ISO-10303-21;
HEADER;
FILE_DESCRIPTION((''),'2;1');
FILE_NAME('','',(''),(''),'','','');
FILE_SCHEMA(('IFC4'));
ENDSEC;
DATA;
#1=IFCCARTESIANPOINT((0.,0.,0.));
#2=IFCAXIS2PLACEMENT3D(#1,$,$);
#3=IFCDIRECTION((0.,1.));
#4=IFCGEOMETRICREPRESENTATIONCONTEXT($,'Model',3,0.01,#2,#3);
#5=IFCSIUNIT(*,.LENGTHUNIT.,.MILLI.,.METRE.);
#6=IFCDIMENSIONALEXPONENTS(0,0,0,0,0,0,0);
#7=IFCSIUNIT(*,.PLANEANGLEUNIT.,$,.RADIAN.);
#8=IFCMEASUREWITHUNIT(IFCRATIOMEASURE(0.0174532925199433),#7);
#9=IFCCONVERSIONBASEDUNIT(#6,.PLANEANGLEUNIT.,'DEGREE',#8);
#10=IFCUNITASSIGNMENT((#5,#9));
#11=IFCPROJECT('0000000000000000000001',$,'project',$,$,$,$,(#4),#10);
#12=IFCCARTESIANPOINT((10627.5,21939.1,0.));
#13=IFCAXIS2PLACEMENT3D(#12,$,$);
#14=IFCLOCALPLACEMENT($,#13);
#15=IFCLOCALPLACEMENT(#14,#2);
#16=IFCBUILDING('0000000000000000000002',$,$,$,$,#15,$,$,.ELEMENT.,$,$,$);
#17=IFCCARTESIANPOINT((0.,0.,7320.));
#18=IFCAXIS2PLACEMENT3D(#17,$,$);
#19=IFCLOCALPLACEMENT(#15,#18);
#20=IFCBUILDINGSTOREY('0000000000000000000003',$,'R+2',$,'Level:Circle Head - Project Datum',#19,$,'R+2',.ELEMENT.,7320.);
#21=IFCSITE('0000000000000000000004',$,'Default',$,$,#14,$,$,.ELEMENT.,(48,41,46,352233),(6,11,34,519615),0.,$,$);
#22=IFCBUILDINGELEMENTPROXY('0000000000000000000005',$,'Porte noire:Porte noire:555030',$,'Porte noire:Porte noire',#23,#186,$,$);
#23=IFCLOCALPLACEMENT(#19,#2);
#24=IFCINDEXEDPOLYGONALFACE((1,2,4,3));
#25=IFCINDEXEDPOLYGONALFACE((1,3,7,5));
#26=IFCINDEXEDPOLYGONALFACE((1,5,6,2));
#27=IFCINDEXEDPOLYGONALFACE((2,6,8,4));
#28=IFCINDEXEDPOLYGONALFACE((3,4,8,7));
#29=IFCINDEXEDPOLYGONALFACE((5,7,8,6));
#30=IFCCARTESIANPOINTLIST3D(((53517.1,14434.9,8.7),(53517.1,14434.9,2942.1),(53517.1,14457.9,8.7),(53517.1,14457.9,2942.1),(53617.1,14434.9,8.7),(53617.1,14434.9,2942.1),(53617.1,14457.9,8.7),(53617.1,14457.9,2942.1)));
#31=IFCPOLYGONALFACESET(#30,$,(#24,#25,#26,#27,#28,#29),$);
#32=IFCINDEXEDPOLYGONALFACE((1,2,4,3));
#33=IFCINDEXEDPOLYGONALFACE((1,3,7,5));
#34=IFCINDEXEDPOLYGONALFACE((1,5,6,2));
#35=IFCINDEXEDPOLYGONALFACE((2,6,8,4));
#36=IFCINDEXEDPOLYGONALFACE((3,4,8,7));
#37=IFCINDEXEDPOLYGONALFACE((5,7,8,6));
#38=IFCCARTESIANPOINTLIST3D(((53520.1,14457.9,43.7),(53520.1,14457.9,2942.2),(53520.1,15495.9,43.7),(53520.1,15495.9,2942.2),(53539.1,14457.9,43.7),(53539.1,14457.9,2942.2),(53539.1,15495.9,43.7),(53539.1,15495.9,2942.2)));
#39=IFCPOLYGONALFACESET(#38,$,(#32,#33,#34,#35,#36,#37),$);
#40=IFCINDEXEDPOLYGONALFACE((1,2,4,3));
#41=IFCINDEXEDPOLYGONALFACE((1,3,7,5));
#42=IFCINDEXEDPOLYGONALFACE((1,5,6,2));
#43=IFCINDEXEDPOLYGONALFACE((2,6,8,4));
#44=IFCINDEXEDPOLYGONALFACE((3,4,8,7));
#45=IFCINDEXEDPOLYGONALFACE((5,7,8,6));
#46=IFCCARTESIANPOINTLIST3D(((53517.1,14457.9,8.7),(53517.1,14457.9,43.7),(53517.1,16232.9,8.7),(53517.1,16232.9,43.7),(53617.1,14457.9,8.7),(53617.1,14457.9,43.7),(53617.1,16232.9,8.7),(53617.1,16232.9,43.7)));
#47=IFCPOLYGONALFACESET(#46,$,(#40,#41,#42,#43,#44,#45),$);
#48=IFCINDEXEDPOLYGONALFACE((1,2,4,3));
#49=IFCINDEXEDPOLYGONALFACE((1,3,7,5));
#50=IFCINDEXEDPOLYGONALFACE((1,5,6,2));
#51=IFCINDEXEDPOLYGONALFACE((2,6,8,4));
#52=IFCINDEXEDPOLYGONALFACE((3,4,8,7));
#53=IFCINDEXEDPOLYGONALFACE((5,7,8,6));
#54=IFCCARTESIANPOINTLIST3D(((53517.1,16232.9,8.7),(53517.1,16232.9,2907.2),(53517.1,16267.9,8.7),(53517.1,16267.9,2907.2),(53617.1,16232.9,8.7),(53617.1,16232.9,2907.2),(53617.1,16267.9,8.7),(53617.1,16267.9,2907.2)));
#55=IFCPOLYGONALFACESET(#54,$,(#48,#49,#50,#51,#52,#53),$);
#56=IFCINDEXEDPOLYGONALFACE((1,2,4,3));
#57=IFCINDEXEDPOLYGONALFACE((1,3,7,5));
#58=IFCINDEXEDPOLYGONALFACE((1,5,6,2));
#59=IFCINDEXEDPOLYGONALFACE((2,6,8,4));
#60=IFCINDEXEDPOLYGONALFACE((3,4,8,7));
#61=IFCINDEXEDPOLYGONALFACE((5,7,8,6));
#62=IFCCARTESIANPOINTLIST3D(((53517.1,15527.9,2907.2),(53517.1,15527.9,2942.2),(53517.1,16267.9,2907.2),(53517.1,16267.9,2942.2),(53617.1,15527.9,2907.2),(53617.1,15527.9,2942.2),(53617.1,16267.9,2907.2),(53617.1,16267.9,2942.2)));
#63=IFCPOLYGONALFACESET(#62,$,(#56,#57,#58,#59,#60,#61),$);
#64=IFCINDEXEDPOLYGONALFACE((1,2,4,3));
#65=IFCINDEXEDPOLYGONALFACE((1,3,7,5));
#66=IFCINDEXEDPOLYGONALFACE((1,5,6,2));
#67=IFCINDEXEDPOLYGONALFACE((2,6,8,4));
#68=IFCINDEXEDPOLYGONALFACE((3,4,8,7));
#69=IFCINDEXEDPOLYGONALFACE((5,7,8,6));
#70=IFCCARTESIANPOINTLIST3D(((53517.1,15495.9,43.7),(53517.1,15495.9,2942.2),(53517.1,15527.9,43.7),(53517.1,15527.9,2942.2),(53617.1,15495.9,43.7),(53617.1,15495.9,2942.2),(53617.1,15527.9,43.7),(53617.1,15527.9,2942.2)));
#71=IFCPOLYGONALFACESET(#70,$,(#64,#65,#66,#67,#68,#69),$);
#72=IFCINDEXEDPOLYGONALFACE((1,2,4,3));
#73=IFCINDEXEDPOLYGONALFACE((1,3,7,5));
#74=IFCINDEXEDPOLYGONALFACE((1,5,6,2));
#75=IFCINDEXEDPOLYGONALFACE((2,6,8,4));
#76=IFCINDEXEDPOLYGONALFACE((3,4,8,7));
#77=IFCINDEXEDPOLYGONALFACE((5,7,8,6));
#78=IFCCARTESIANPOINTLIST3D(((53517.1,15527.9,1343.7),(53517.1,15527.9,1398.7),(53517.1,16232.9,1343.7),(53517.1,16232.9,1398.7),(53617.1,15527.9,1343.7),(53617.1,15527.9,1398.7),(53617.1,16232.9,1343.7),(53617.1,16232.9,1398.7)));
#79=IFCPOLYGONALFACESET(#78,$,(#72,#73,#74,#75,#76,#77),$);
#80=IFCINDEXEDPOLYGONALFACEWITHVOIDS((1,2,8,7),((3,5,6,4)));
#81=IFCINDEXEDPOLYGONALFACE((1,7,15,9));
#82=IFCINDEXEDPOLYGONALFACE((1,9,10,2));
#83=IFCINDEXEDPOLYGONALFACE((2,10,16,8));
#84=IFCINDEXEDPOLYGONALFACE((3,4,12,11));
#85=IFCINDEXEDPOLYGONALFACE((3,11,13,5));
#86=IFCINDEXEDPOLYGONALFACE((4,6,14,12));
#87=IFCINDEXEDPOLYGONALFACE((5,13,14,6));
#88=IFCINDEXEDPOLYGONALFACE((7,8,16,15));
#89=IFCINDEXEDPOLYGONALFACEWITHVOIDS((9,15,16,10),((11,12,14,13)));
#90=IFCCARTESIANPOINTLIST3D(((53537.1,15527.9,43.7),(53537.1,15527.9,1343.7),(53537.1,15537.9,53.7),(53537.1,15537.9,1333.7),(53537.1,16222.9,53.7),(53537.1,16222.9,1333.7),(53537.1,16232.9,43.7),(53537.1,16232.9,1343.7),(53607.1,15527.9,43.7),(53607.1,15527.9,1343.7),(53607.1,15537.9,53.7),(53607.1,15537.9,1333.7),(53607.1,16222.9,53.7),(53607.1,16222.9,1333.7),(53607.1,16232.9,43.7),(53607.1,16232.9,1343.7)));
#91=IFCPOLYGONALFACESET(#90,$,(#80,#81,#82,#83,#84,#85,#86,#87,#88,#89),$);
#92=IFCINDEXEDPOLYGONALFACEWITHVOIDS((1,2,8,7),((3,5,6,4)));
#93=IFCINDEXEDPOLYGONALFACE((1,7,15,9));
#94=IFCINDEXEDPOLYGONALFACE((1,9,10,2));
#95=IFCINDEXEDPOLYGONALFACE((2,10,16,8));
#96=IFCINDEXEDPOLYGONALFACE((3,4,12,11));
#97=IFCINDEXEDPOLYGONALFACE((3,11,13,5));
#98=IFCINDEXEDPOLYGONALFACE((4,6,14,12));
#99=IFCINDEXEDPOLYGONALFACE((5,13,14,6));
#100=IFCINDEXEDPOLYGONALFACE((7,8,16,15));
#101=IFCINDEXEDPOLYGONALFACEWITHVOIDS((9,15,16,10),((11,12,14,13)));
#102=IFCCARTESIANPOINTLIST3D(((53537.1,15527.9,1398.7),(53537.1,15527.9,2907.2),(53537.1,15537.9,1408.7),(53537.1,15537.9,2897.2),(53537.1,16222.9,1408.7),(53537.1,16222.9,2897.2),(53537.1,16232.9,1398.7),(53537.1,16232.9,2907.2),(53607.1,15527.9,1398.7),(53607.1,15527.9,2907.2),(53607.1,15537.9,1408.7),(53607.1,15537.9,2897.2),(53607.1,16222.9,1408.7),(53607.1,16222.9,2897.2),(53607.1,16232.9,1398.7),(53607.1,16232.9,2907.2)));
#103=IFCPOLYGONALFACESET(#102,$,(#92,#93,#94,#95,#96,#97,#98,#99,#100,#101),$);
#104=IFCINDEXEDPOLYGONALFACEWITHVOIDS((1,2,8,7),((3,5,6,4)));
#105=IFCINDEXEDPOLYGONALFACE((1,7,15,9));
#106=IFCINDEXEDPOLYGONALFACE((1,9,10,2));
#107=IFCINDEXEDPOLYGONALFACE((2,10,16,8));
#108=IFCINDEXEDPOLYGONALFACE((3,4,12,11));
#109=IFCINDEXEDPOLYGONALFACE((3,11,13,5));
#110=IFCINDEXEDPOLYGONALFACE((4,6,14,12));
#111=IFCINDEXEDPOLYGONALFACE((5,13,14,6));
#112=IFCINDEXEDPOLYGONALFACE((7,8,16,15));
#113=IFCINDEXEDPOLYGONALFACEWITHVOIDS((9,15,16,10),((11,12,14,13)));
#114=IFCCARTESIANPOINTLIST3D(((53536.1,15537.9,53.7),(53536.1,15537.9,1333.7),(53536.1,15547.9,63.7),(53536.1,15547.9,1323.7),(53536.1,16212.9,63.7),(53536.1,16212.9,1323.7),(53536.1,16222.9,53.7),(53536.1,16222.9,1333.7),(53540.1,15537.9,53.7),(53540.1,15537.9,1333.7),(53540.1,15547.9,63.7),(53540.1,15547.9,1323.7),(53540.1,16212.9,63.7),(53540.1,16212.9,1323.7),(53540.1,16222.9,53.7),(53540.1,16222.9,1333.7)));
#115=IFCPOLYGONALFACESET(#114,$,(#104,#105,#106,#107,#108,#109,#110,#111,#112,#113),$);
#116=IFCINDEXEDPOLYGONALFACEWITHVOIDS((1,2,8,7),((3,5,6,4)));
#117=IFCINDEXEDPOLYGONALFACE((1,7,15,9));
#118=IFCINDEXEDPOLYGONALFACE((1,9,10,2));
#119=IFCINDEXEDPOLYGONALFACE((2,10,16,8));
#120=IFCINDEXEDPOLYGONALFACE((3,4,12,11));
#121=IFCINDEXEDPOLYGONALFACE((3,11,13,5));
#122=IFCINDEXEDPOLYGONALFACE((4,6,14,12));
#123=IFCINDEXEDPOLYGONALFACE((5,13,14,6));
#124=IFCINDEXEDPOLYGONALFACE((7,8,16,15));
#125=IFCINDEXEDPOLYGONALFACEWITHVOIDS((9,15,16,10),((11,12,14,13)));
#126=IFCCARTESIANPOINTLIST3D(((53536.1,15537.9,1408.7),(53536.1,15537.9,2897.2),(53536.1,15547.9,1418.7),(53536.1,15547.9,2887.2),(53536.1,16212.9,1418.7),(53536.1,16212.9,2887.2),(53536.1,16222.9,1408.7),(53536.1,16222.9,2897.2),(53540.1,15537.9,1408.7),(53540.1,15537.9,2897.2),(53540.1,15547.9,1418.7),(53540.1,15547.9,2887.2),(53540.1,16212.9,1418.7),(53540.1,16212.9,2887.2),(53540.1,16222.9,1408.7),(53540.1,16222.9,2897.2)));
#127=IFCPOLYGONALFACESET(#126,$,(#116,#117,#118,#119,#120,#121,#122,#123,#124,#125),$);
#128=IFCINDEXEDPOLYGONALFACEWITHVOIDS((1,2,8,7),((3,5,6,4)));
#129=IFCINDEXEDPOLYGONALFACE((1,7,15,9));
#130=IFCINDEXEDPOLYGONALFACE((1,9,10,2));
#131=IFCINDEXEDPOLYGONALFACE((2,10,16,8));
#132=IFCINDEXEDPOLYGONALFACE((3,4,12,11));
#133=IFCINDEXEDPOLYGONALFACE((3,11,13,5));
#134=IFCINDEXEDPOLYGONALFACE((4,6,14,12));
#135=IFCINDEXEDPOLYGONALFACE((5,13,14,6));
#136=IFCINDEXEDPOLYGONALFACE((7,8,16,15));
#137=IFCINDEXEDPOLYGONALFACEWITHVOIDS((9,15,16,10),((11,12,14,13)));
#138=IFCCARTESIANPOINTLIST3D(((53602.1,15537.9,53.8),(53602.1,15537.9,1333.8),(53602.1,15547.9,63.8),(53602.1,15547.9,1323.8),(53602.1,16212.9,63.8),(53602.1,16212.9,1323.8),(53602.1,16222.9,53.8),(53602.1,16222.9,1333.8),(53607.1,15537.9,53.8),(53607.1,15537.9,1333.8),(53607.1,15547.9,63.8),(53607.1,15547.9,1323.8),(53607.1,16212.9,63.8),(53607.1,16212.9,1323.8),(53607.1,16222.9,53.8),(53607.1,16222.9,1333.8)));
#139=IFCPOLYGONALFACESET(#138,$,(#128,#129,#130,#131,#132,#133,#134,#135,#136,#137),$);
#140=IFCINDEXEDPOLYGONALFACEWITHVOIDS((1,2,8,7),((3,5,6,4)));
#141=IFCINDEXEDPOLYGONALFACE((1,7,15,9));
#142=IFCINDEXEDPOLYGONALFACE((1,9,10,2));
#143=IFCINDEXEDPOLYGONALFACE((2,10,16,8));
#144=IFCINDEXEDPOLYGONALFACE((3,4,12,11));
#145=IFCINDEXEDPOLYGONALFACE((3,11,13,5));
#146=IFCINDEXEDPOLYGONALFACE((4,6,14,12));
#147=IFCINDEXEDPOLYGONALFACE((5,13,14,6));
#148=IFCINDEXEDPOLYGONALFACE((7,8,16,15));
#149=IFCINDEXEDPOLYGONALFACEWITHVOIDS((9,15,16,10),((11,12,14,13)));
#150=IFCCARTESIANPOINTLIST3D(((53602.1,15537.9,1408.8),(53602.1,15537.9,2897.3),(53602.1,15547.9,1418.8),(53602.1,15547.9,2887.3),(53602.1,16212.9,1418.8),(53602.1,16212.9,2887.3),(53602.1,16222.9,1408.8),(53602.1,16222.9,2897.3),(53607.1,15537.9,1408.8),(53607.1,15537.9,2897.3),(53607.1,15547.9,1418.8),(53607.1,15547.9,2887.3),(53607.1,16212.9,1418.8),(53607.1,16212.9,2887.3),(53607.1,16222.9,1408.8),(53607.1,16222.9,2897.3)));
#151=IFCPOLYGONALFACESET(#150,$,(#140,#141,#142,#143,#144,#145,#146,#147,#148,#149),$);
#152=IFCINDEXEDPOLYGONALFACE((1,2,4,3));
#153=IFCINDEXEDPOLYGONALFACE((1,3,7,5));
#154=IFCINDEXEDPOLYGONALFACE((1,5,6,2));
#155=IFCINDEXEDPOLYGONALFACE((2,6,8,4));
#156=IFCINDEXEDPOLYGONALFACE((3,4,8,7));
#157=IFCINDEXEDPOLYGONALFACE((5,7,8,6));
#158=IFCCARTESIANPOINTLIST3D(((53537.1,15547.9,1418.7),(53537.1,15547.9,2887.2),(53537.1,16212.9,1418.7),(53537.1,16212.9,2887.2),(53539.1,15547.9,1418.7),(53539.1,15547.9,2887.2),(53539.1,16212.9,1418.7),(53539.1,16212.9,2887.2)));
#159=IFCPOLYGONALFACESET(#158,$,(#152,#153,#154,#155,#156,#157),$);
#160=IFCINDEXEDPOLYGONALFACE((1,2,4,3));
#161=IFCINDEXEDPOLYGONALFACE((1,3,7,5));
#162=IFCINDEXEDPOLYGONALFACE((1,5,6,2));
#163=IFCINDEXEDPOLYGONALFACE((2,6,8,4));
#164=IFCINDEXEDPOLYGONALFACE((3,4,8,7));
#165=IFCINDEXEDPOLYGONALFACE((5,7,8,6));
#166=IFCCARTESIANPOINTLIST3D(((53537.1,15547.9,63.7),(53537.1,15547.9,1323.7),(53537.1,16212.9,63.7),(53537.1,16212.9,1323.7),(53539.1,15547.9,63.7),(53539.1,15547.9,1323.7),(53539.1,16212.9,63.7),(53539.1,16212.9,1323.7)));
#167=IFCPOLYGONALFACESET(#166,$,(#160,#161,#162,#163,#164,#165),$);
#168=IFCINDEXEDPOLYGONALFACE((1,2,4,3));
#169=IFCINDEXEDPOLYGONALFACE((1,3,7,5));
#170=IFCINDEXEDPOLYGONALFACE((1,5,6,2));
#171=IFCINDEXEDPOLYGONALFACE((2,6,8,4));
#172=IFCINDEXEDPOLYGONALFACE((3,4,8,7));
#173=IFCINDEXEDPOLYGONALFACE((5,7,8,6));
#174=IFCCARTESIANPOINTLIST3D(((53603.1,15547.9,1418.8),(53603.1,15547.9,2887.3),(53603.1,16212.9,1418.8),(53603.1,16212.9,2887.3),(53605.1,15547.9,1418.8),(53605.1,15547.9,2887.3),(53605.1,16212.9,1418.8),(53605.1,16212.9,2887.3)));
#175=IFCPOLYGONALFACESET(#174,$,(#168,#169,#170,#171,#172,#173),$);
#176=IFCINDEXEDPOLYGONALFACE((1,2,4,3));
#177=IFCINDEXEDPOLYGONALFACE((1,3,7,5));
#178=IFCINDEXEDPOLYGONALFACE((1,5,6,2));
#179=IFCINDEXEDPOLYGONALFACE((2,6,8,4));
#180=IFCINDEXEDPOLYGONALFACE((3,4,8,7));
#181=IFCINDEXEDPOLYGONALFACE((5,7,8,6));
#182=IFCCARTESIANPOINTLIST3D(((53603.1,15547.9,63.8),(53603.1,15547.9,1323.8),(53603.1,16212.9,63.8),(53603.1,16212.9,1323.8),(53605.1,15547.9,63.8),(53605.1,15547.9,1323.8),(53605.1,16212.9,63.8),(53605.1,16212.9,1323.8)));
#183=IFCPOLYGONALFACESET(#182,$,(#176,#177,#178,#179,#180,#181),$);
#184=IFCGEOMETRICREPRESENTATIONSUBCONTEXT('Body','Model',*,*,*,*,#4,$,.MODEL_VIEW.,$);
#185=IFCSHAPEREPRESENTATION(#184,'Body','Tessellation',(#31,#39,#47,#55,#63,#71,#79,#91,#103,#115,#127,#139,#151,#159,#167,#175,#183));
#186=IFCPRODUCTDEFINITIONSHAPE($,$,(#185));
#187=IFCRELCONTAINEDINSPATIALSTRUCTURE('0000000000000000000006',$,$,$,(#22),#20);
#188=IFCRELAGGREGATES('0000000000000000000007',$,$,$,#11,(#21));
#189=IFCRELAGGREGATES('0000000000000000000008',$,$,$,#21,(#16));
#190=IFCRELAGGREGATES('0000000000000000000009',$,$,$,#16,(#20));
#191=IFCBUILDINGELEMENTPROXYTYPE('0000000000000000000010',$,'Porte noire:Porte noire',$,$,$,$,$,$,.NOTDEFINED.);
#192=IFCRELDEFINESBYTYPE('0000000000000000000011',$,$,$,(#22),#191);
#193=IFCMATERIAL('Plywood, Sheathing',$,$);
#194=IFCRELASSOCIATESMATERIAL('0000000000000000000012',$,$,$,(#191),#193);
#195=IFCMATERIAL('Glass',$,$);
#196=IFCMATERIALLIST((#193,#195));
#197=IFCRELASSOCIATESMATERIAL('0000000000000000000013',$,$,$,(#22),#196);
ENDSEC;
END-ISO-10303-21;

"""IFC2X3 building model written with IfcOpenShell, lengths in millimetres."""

from ifc_helpers import new_model, entity, si_unit, converted_unit, direction, frame, frame_2d, origin, origin_2d_with_axis, place, context, subcontext, project, spatial, polyline, rectangle, outline, extrude, source, transform, mapped, material, material_list, type_object, type_shapes, element, save


model = new_model("IFC2X3")

# Units and contexts
model_context = context("Model", 3, precision=0.01, world=origin(), true_north=direction((0.0, 1.0)))
body_context = subcontext(model_context, "Body", "Model", "MODEL_VIEW")
ifc_project = project(units=[si_unit("LENGTHUNIT", "METRE", prefix="MILLI"), converted_unit("PLANEANGLEUNIT", "DEGREE", entity("IfcRatioMeasure", 0.0174532925199433), si_unit("PLANEANGLEUNIT", "RADIAN"), dimensions=[0, 0, 0, 0, 0, 0, 0])], contexts=[model_context])

# Site, building, storey
site_placement = place(None, frame((10627.5, 21939.1, 0.0)))
site = spatial("IfcSite", under=ifc_project, at=site_placement, Name="Default", CompositionType="ELEMENT", RefLatitude=(48, 41, 46, 352233), RefLongitude=(6, 11, 34, 519615), RefElevation=0.0)
building_placement = place(site_placement, origin())
building = spatial("IfcBuilding", under=site, at=building_placement, CompositionType="ELEMENT")
storey_placement = place(building_placement, frame((0.0, 0.0, 7320.0)))
storey = spatial("IfcBuildingStorey", under=building, at=storey_placement, Name="R+2", ObjectType="Level:Circle Head - Project Datum", LongName="R+2", CompositionType="ELEMENT", Elevation=7320.0)

# Building element proxy
ifc_material_1 = material(Name="Glass")
ifc_material_2 = material(Name="Plywood, Sheathing")
building_element_proxy_type_1 = type_object("IfcBuildingElementProxyType", Name="Porte noire:Porte noire", PredefinedType="NOTDEFINED", material=ifc_material_2)
shared_shape_1 = source(origin(), body_context, "Body", "SweptSolid", [
    extrude(rectangle(XDim=23.0, YDim=100.0, at=frame_2d((0.0, 0.0), x_axis=(1.0, 0.0))), frame((-950.9, 50.0, 8.7), z_axis=(0.0, 0.0, 1.0), x_axis=(-1.0, 0.0, 0.0)), (0.0, 0.0, 1.0), 2933.3),
    extrude(rectangle(XDim=1038.0, YDim=19.0, at=frame_2d((0.0, 0.0), x_axis=(1.0, 0.0))), frame((-420.4, 87.5, 43.7), z_axis=(0.0, 0.0, 1.0), x_axis=(-1.0, 0.0, 0.0)), (0.0, 0.0, 1.0), 2898.5),
    extrude(rectangle(XDim=1775.0, YDim=100.0, at=origin_2d_with_axis()), frame((-51.9, 50.0, 8.7), z_axis=(0.0, 0.0, 1.0), x_axis=(-1.0, 0.0, 0.0)), (0.0, 0.0, 1.0), 35.0),
    extrude(rectangle(XDim=35.0, YDim=100.0, at=origin_2d_with_axis()), frame((853.1, 50.0, 8.7), z_axis=(0.0, 0.0, 1.0), x_axis=(-1.0, 0.0, 0.0)), (0.0, 0.0, 1.0), 2898.5),
    extrude(rectangle(XDim=740.0, YDim=100.0, at=origin_2d_with_axis()), frame((500.6, 50.0, 2907.2), z_axis=(0.0, 0.0, 1.0), x_axis=(-1.0, 0.0, 0.0)), (0.0, 0.0, 1.0), 35.0),
    extrude(rectangle(XDim=32.0, YDim=100.0, at=origin_2d_with_axis()), frame((114.6, 50.0, 43.7), z_axis=(0.0, 0.0, 1.0), x_axis=(-1.0, 0.0, 0.0)), (0.0, 0.0, 1.0), 2898.5),
    extrude(rectangle(XDim=705.0, YDim=100.0, at=origin_2d_with_axis()), frame((483.1, 50.0, 1343.7), z_axis=(0.0, 0.0, 1.0), x_axis=(-1.0, 0.0, 0.0)), (0.0, 0.0, 1.0), 55.0),
    extrude(outline(polyline([(-352.5, -650.0), (352.5, -650.0), (352.5, 650.0), (-352.5, 650.0), (-352.5, -650.0)]), holes=[polyline([(342.5, 640.0), (342.5, -640.0), (-342.5, -640.0), (-342.5, 640.0), (342.5, 640.0)])]), frame((483.1, 10.0, 693.7), z_axis=(0.0, 1.0, 0.0), x_axis=(1.0, 0.0, 0.0)), (0.0, 0.0, 1.0), 70.0),
    extrude(outline(polyline([(-754.2, -352.5), (754.2, -352.5), (754.2, 352.5), (-754.2, 352.5), (-754.2, -352.5)]), holes=[polyline([(744.2, 342.5), (744.2, -342.5), (-744.2, -342.5), (-744.2, 342.5), (744.2, 342.5)])]), frame((483.1, 10.0, 2153.0), z_axis=(0.0, 1.0, 0.0), x_axis=(0.0, 0.0, 1.0)), (0.0, 0.0, 1.0), 70.0),
    extrude(outline(polyline([(-640.0, -342.5), (640.0, -342.5), (640.0, 342.5), (-640.0, 342.5), (-640.0, -342.5)]), holes=[polyline([(630.0, 332.5), (630.0, -332.5), (-630.0, -332.5), (-630.0, 332.5), (630.0, 332.5)])]), frame((483.1, 77.0, 693.7), z_axis=(0.0, 1.0, 0.0), x_axis=(0.0, 0.0, 1.0)), (0.0, 0.0, 1.0), 4.0),
    extrude(outline(polyline([(-744.2, -342.5), (744.2, -342.5), (744.2, 342.5), (-744.2, 342.5), (-744.2, -342.5)]), holes=[polyline([(734.2, 332.5), (734.2, -332.5), (-734.2, -332.5), (-734.2, 332.5), (734.2, 332.5)])]), frame((483.1, 77.0, 2153.0), z_axis=(0.0, 1.0, 0.0), x_axis=(0.0, 0.0, 1.0)), (0.0, 0.0, 1.0), 4.0),
    extrude(outline(polyline([(-640.0, -342.5), (640.0, -342.5), (640.0, 342.5), (-640.0, 342.5), (-640.0, -342.5)]), holes=[polyline([(630.0, 332.5), (630.0, -332.5), (-630.0, -332.5), (-630.0, 332.5), (630.0, 332.5)])]), frame((483.1, 10.0, 693.8), z_axis=(0.0, 1.0, 0.0), x_axis=(0.0, 0.0, 1.0)), (0.0, 0.0, 1.0), 5.0),
    extrude(outline(polyline([(-744.2, -342.5), (744.2, -342.5), (744.2, 342.5), (-744.2, 342.5), (-744.2, -342.5)]), holes=[polyline([(734.2, 332.5), (734.2, -332.5), (-734.2, -332.5), (-734.2, 332.5), (734.2, 332.5)])]), frame((483.1, 10.0, 2153.0), z_axis=(0.0, 1.0, 0.0), x_axis=(0.0, 0.0, 1.0)), (0.0, 0.0, 1.0), 5.0),
    extrude(rectangle(XDim=665.0, YDim=2.0, at=frame_2d((0.0, 0.0), x_axis=(1.0, 0.0))), frame((483.1, 79.0, 1418.7), z_axis=(0.0, 0.0, 1.0), x_axis=(-1.0, 0.0, 0.0)), (0.0, 0.0, 1.0), 1468.5),
    extrude(rectangle(XDim=665.0, YDim=2.0, at=frame_2d((0.0, 0.0), x_axis=(1.0, 0.0))), frame((483.1, 79.0, 63.7), z_axis=(0.0, 0.0, 1.0), x_axis=(-1.0, 0.0, 0.0)), (0.0, 0.0, 1.0), 1260.0),
    extrude(rectangle(XDim=665.0, YDim=2.0, at=frame_2d((0.0, 0.0), x_axis=(1.0, 0.0))), frame((483.1, 13.0, 1418.8), z_axis=(0.0, 0.0, 1.0), x_axis=(-1.0, 0.0, 0.0)), (0.0, 0.0, 1.0), 1468.5),
    extrude(rectangle(XDim=665.0, YDim=2.0, at=frame_2d((0.0, 0.0), x_axis=(1.0, 0.0))), frame((483.1, 13.0, 63.8), z_axis=(0.0, 0.0, 1.0), x_axis=(-1.0, 0.0, 0.0)), (0.0, 0.0, 1.0), 1260.0),
])
type_shapes(building_element_proxy_type_1, [shared_shape_1])
ifc_material_list_1 = material_list([ifc_material_2, ifc_material_1])
proxy_1_placement = place(storey_placement, frame((53617.1, 15397.3, 0.0), z_axis=(0.0, 0.0, 1.0), x_axis=(0.0, 1.0, 0.0)))
element("IfcBuildingElementProxy", 1, at=proxy_1_placement, inside=storey, type_object=building_element_proxy_type_1, material=ifc_material_list_1, Name="Porte noire:Porte noire:555030", ObjectType="Porte noire:Porte noire", context=body_context, shape_type="MappedRepresentation", body=[
    mapped(shared_shape_1, transform((0.0, 0.0, 0.0), scale=1.0)),
])

save(model, "model.ifc")
